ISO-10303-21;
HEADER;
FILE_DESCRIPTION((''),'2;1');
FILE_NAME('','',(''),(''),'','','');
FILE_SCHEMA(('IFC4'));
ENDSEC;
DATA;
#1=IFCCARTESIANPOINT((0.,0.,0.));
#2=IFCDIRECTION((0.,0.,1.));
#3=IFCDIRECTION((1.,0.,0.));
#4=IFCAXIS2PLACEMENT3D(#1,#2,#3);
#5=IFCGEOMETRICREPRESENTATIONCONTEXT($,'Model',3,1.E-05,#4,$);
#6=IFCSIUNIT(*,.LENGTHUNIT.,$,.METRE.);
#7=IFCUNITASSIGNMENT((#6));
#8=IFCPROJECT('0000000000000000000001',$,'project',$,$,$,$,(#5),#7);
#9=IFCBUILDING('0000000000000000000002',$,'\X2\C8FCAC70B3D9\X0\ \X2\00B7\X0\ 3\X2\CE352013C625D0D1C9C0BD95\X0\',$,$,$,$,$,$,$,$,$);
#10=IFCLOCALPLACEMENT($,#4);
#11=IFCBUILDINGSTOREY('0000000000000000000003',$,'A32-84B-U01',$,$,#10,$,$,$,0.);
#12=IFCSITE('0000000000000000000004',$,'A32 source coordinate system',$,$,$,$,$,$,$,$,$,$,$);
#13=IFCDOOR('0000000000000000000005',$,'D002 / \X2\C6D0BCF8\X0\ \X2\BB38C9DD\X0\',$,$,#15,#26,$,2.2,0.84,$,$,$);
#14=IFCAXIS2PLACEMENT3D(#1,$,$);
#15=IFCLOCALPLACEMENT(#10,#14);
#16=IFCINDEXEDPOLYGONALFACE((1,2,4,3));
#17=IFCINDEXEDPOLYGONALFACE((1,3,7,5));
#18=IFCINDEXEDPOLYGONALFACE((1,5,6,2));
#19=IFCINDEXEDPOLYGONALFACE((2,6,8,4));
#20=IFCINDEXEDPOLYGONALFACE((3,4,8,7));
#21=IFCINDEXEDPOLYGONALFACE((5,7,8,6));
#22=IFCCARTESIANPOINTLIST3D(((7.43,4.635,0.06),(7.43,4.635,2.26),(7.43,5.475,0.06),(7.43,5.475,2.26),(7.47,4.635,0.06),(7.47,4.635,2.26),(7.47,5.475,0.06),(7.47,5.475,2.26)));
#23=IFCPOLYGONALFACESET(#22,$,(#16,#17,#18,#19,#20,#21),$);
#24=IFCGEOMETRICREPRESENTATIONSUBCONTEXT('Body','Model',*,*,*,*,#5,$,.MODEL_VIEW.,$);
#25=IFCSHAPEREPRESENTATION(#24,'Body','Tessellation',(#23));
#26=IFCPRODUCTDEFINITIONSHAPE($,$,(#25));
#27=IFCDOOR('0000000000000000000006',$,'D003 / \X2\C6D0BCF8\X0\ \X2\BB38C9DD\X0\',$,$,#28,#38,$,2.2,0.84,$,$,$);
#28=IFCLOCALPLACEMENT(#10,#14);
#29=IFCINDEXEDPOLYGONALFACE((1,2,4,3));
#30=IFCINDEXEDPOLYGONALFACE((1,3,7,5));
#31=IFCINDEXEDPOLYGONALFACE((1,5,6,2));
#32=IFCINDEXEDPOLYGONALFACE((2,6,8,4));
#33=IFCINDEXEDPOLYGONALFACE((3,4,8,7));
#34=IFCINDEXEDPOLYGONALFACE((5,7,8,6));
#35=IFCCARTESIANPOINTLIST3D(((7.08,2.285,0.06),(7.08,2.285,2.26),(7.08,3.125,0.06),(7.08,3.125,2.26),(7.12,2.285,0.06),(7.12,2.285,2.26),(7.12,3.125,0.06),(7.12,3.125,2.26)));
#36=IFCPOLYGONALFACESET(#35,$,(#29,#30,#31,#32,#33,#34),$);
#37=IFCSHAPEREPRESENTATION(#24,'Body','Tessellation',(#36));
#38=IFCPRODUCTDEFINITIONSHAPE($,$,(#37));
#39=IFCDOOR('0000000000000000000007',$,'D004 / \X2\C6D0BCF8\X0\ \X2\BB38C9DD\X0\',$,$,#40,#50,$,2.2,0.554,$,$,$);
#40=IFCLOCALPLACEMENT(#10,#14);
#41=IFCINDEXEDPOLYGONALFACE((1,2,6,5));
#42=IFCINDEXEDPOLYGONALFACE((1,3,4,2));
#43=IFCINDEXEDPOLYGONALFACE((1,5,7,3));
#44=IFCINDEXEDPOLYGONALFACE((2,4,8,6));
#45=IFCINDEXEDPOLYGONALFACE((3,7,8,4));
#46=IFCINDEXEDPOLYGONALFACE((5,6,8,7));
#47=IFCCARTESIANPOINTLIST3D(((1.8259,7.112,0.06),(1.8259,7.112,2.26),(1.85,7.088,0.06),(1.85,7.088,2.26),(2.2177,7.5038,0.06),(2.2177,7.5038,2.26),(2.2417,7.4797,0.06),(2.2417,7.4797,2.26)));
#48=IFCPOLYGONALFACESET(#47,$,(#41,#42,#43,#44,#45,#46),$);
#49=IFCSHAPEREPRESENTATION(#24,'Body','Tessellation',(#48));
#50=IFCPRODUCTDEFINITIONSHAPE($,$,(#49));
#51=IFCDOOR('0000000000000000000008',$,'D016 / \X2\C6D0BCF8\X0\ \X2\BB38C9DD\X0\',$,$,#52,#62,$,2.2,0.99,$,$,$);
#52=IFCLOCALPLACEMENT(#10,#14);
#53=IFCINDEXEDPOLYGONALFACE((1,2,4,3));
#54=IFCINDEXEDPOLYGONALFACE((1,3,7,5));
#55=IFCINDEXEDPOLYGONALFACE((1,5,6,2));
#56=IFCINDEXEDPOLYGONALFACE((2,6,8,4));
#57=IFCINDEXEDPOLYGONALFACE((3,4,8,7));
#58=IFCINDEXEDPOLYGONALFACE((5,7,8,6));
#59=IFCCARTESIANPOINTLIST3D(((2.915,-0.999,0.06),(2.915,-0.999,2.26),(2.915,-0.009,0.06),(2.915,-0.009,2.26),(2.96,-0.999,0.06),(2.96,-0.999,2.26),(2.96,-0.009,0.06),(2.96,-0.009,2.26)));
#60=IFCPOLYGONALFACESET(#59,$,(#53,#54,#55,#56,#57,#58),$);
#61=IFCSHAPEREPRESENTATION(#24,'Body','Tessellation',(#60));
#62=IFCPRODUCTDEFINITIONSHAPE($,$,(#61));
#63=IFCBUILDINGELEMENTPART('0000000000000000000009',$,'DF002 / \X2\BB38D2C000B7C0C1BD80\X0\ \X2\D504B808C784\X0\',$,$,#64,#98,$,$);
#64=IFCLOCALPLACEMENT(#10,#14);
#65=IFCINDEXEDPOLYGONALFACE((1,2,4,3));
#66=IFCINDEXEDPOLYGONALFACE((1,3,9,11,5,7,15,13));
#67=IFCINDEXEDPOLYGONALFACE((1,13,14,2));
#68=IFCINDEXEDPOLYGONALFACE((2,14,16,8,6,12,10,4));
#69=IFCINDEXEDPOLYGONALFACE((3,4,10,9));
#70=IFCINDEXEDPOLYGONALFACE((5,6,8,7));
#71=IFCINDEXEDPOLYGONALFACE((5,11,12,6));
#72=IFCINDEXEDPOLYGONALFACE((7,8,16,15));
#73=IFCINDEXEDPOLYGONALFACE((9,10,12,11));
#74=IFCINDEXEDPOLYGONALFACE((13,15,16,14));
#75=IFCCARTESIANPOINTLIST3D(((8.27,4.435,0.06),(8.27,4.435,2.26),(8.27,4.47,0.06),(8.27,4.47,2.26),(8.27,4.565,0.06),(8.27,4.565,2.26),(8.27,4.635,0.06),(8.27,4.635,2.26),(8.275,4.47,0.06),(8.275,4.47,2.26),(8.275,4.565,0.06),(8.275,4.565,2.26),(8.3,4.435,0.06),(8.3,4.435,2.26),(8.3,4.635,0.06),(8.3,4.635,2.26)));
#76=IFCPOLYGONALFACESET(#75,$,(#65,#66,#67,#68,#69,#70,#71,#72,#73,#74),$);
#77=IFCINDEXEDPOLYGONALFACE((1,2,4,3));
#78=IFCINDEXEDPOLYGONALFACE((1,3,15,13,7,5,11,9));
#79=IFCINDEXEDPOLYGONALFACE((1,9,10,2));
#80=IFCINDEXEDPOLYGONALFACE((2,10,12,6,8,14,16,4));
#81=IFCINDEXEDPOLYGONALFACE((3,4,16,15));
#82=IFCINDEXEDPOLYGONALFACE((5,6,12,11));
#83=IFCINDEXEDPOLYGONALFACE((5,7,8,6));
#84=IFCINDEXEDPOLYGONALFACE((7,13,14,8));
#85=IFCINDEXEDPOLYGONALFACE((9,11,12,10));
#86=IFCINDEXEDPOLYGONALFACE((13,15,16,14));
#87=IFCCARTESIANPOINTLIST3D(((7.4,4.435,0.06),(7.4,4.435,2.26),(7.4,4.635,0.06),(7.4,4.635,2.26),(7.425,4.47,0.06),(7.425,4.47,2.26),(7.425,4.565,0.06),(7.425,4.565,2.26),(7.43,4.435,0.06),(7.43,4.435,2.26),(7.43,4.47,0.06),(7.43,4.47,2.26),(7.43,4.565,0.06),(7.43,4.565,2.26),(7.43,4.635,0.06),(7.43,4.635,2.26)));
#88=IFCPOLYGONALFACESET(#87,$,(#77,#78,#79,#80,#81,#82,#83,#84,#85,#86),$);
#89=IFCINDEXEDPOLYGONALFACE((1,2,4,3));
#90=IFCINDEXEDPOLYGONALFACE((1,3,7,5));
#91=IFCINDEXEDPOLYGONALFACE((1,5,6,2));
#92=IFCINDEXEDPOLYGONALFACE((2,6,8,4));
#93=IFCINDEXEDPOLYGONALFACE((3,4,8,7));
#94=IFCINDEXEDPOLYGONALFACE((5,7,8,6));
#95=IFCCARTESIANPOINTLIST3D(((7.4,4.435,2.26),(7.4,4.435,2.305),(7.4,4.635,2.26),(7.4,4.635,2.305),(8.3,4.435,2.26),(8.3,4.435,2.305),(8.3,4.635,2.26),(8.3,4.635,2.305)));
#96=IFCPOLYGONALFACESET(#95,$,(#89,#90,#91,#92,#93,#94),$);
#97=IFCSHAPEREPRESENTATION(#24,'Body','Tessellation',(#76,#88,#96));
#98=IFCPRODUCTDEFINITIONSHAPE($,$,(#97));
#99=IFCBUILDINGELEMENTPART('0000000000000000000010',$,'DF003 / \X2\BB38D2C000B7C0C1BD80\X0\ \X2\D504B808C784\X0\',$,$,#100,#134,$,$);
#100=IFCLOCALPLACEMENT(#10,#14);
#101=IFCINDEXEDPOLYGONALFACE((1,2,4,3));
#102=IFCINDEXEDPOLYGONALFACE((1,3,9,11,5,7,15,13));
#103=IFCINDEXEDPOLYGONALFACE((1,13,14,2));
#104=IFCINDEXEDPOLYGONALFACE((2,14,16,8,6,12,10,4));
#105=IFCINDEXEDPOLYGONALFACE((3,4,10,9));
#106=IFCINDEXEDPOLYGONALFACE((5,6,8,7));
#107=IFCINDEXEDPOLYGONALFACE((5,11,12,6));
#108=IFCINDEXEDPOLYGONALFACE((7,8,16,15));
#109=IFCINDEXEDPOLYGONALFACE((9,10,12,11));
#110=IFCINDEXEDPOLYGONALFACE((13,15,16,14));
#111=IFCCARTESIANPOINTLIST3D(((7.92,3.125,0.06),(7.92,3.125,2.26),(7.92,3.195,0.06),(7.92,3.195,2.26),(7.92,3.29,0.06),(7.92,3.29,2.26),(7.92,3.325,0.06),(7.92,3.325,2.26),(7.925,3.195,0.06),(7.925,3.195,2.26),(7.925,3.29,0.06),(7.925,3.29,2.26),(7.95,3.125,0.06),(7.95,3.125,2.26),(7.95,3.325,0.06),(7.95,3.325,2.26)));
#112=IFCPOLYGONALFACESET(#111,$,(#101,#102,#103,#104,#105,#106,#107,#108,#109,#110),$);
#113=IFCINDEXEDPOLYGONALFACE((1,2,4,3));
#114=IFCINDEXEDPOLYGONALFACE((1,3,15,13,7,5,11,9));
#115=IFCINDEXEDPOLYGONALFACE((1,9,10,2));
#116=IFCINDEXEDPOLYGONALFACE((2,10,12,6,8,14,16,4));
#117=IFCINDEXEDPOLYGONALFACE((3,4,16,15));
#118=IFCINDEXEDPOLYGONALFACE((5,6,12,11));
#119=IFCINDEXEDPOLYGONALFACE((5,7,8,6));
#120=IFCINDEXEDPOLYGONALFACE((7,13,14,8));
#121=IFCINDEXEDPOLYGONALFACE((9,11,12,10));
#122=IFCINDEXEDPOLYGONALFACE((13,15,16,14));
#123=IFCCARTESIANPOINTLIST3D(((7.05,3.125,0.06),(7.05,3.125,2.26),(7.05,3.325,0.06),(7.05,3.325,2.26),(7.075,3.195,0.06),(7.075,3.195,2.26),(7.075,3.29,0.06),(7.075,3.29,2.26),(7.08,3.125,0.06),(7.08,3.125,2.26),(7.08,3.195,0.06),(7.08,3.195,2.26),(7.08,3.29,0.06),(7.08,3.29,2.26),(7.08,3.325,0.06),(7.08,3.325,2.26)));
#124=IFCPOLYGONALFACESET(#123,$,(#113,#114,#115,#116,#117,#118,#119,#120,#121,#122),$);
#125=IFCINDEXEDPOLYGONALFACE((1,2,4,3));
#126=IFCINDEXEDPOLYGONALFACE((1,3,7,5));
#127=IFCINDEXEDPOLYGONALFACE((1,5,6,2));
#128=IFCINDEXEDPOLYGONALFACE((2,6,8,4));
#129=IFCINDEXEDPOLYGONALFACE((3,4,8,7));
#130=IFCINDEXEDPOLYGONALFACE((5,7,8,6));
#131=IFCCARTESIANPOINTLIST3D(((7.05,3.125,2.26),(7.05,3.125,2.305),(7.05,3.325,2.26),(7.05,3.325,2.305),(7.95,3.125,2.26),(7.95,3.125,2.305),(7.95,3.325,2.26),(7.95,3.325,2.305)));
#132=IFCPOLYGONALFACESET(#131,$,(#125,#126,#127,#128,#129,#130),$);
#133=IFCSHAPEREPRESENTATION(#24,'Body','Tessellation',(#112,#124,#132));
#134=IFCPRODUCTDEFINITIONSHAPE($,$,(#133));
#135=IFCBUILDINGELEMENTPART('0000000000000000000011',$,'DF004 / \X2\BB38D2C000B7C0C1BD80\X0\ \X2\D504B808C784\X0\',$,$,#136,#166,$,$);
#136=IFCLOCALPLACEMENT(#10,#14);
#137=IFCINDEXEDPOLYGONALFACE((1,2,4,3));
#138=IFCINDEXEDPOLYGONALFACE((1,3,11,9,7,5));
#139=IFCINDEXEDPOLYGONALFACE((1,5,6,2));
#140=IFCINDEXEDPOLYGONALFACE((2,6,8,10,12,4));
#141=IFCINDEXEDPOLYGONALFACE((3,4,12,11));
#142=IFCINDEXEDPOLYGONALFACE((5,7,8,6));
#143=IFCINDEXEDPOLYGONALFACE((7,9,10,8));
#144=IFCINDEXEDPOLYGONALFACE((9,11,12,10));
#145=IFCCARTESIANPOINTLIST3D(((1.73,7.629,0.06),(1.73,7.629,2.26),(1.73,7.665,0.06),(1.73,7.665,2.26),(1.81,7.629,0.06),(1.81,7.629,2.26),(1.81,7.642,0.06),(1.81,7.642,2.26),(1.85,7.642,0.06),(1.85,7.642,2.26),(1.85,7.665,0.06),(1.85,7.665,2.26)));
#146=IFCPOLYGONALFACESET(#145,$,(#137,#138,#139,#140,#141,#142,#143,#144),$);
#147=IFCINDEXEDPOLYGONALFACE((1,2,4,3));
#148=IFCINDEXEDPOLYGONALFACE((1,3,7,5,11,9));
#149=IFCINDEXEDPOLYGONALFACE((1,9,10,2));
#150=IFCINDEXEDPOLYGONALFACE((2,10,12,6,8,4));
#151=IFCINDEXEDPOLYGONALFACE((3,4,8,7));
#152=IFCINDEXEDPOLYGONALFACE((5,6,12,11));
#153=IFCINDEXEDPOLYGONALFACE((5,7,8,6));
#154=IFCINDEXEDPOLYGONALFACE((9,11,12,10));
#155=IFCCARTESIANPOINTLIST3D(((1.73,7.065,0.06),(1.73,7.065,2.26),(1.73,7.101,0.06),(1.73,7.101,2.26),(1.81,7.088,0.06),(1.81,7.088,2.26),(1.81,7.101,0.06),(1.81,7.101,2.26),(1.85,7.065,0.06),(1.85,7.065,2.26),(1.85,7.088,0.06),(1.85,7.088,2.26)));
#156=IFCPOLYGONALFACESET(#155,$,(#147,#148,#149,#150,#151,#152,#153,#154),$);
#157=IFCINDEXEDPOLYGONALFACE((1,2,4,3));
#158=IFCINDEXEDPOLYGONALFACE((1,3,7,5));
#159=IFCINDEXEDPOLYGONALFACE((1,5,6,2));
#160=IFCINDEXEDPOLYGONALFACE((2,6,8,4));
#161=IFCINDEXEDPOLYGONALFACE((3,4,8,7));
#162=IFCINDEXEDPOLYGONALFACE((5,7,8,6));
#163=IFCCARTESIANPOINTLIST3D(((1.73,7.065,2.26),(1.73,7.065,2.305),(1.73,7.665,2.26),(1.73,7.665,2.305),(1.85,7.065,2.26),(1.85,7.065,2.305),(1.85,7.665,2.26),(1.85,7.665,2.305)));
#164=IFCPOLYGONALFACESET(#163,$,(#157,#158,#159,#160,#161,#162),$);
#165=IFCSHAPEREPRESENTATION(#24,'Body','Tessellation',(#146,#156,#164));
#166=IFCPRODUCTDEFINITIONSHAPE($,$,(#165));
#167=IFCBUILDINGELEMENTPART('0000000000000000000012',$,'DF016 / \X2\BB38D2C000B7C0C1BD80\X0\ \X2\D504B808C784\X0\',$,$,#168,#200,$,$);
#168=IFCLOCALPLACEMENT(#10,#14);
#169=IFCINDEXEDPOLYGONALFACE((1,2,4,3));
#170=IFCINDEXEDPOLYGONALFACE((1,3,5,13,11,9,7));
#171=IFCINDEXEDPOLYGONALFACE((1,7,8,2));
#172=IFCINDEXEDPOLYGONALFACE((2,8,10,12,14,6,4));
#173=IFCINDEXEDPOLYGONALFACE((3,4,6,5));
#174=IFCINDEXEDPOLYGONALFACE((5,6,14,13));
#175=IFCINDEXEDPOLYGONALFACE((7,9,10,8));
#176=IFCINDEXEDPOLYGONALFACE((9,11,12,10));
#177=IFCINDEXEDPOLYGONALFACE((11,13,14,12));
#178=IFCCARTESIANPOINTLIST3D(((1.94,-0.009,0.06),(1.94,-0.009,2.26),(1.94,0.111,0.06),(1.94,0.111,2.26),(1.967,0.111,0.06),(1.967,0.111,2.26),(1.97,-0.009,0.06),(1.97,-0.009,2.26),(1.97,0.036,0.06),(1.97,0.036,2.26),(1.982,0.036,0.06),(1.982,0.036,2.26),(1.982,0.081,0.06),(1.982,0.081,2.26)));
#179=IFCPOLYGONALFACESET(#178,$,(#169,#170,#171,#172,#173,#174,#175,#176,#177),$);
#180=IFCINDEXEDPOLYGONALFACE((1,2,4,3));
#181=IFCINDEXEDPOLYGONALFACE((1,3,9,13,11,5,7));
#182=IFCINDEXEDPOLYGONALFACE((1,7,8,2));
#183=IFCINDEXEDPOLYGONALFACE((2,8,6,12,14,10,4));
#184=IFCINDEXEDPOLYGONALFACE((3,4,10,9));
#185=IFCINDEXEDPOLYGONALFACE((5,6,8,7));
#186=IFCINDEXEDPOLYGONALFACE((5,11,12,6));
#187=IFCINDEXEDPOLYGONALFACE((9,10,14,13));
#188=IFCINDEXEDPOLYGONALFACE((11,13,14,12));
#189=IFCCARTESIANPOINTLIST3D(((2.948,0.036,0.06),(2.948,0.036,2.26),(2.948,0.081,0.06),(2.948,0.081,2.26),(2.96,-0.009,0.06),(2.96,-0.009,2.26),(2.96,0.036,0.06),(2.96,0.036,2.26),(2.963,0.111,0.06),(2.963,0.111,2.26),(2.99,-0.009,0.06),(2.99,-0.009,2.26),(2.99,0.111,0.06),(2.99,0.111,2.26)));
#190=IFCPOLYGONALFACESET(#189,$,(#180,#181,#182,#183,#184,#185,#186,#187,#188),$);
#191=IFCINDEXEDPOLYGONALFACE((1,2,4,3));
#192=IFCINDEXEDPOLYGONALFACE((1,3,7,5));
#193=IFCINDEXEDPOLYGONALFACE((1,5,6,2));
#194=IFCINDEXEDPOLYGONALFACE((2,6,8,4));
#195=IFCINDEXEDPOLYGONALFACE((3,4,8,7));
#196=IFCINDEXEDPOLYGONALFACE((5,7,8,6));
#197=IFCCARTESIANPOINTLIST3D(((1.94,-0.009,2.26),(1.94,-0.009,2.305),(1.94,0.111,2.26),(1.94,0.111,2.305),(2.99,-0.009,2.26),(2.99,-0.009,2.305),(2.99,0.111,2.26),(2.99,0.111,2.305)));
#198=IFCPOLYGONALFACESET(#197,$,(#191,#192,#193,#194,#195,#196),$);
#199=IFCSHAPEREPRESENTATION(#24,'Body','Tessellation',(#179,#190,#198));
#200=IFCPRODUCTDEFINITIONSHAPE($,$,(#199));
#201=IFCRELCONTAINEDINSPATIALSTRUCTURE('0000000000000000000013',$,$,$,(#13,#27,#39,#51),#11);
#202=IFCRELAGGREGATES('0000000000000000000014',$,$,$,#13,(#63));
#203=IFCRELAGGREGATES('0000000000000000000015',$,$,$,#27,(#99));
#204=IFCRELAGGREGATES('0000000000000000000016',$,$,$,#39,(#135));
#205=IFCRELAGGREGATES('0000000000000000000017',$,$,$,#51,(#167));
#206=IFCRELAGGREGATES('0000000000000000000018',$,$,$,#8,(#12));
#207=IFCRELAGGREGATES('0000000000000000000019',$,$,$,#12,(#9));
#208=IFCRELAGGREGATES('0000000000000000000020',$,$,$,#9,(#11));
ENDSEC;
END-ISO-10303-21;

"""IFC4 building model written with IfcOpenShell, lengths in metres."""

from ifc_helpers import new_model, si_unit, frame, origin_with_axes, place, context, subcontext, project, spatial, polyline, outline, extrude, element, aggregate, save


model = new_model("IFC4")

# Units and contexts
model_context = context("Model", 3, precision=1e-05, world=origin_with_axes())
body_context = subcontext(model_context, "Body", "Model", "MODEL_VIEW")
ifc_project = project(units=[si_unit("LENGTHUNIT", "METRE")], contexts=[model_context])

# Site, building, storey
storey_placement = place(None, origin_with_axes())
site = spatial("IfcSite", under=ifc_project, Name="A32 source coordinate system")
building = spatial("IfcBuilding", under=site, Name="주거동 · 3층–옥탑지붕")
storey = spatial("IfcBuildingStorey", under=building, at=storey_placement, Name="A32-84B-U01", Elevation=0.0)

# Doors
door_1_placement = place(storey_placement, origin_with_axes())
door_1 = element("IfcDoor", 1, at=door_1_placement, inside=storey, Name="D002 / 원본 문짝", OverallHeight=2.2, OverallWidth=0.84, context=body_context, shape_type="SweptSolid", body=[
    extrude(outline(polyline([(7.43, 4.635), (7.43, 5.475), (7.47, 5.475), (7.47, 4.635), (7.43, 4.635)])), frame((0.0, 0.0, 0.06)), (0.0, 0.0, 1.0), 2.2),
])
door_2_placement = place(storey_placement, origin_with_axes())
door_2 = element("IfcDoor", 2, at=door_2_placement, inside=storey, Name="D003 / 원본 문짝", OverallHeight=2.2, OverallWidth=0.84, context=body_context, shape_type="SweptSolid", body=[
    extrude(outline(polyline([(7.12, 2.285), (7.08, 2.285), (7.08, 3.125), (7.12, 3.125), (7.12, 2.285)])), frame((0.0, 0.0, 0.06)), (0.0, 0.0, 1.0), 2.2),
])
door_3_placement = place(storey_placement, origin_with_axes())
door_3 = element("IfcDoor", 3, at=door_3_placement, inside=storey, Name="D004 / 원본 문짝", OverallHeight=2.2, OverallWidth=0.554, context=body_context, shape_type="SweptSolid", body=[
    extrude(outline(polyline([(2.2177, 7.5038), (2.2417, 7.4797), (1.85, 7.088), (1.8259, 7.112), (2.2177, 7.5038)])), frame((0.0, 0.0, 0.06)), (0.0, 0.0, 1.0), 2.2),
])
door_4_placement = place(storey_placement, origin_with_axes())
door_4 = element("IfcDoor", 4, at=door_4_placement, inside=storey, Name="D016 / 원본 문짝", OverallHeight=2.2, OverallWidth=0.99, context=body_context, shape_type="SweptSolid", body=[
    extrude(outline(polyline([(2.96, -0.009), (2.96, -0.999), (2.915, -0.999), (2.915, -0.009), (2.96, -0.009)])), frame((0.0, 0.0, 0.06)), (0.0, 0.0, 1.0), 2.2),
])

# Building element parts
building_element_part_1_placement = place(door_1_placement, origin_with_axes())
building_element_part_1 = element("IfcBuildingElementPart", 5, at=building_element_part_1_placement, Name="DF002 / 문틀·상부 프레임", context=body_context, shape_type="SweptSolid", body=[
    extrude(outline(polyline([(8.3, 4.435), (8.27, 4.435), (8.27, 4.47), (8.275, 4.47), (8.275, 4.565), (8.27, 4.565), (8.27, 4.635), (8.3, 4.635), (8.3, 4.435)])), frame((0.0, 0.0, 0.06)), (0.0, 0.0, 1.0), 2.2),
    extrude(outline(polyline([(7.43, 4.635), (7.43, 4.565), (7.425, 4.565), (7.425, 4.47), (7.43, 4.47), (7.43, 4.435), (7.4, 4.435), (7.4, 4.635), (7.43, 4.635)])), frame((0.0, 0.0, 0.06)), (0.0, 0.0, 1.0), 2.2),
    extrude(outline(polyline([(7.4, 4.435), (7.4, 4.635), (8.3, 4.635), (8.3, 4.435), (7.4, 4.435)])), frame((0.0, 0.0, 2.26)), (0.0, 0.0, 1.0), 0.045),
])
aggregate(door_1, [building_element_part_1])
building_element_part_2_placement = place(door_2_placement, origin_with_axes())
building_element_part_2 = element("IfcBuildingElementPart", 6, at=building_element_part_2_placement, Name="DF003 / 문틀·상부 프레임", context=body_context, shape_type="SweptSolid", body=[
    extrude(outline(polyline([(7.92, 3.125), (7.92, 3.195), (7.925, 3.195), (7.925, 3.29), (7.92, 3.29), (7.92, 3.325), (7.95, 3.325), (7.95, 3.125), (7.92, 3.125)])), frame((0.0, 0.0, 0.06)), (0.0, 0.0, 1.0), 2.2),
    extrude(outline(polyline([(7.05, 3.325), (7.08, 3.325), (7.08, 3.29), (7.075, 3.29), (7.075, 3.195), (7.08, 3.195), (7.08, 3.125), (7.05, 3.125), (7.05, 3.325)])), frame((0.0, 0.0, 0.06)), (0.0, 0.0, 1.0), 2.2),
    extrude(outline(polyline([(7.05, 3.125), (7.05, 3.325), (7.95, 3.325), (7.95, 3.125), (7.05, 3.125)])), frame((0.0, 0.0, 2.26)), (0.0, 0.0, 1.0), 0.045),
])
aggregate(door_2, [building_element_part_2])
building_element_part_3_placement = place(door_3_placement, origin_with_axes())
building_element_part_3 = element("IfcBuildingElementPart", 7, at=building_element_part_3_placement, Name="DF004 / 문틀·상부 프레임", context=body_context, shape_type="SweptSolid", body=[
    extrude(outline(polyline([(1.85, 7.665), (1.85, 7.642), (1.81, 7.642), (1.81, 7.629), (1.73, 7.629), (1.73, 7.665), (1.85, 7.665)])), frame((0.0, 0.0, 0.06)), (0.0, 0.0, 1.0), 2.2),
    extrude(outline(polyline([(1.73, 7.101), (1.81, 7.101), (1.81, 7.088), (1.85, 7.088), (1.85, 7.065), (1.73, 7.065), (1.73, 7.101)])), frame((0.0, 0.0, 0.06)), (0.0, 0.0, 1.0), 2.2),
    extrude(outline(polyline([(1.73, 7.065), (1.73, 7.665), (1.85, 7.665), (1.85, 7.065), (1.73, 7.065)])), frame((0.0, 0.0, 2.26)), (0.0, 0.0, 1.0), 0.045),
])
aggregate(door_3, [building_element_part_3])
building_element_part_4_placement = place(door_4_placement, origin_with_axes())
building_element_part_4 = element("IfcBuildingElementPart", 8, at=building_element_part_4_placement, Name="DF016 / 문틀·상부 프레임", context=body_context, shape_type="SweptSolid", body=[
    extrude(outline(polyline([(1.94, 0.111), (1.967, 0.111), (1.982, 0.081), (1.982, 0.036), (1.97, 0.036), (1.97, -0.009), (1.94, -0.009), (1.94, 0.111)])), frame((0.0, 0.0, 0.06)), (0.0, 0.0, 1.0), 2.2),
    extrude(outline(polyline([(2.96, -0.009), (2.96, 0.036), (2.948, 0.036), (2.948, 0.081), (2.963, 0.111), (2.99, 0.111), (2.99, -0.009), (2.96, -0.009)])), frame((0.0, 0.0, 0.06)), (0.0, 0.0, 1.0), 2.2),
    extrude(outline(polyline([(1.94, -0.009), (1.94, 0.111), (2.99, 0.111), (2.99, -0.009), (1.94, -0.009)])), frame((0.0, 0.0, 2.26)), (0.0, 0.0, 1.0), 0.045),
])
aggregate(door_4, [building_element_part_4])

save(model, "model.ifc")
